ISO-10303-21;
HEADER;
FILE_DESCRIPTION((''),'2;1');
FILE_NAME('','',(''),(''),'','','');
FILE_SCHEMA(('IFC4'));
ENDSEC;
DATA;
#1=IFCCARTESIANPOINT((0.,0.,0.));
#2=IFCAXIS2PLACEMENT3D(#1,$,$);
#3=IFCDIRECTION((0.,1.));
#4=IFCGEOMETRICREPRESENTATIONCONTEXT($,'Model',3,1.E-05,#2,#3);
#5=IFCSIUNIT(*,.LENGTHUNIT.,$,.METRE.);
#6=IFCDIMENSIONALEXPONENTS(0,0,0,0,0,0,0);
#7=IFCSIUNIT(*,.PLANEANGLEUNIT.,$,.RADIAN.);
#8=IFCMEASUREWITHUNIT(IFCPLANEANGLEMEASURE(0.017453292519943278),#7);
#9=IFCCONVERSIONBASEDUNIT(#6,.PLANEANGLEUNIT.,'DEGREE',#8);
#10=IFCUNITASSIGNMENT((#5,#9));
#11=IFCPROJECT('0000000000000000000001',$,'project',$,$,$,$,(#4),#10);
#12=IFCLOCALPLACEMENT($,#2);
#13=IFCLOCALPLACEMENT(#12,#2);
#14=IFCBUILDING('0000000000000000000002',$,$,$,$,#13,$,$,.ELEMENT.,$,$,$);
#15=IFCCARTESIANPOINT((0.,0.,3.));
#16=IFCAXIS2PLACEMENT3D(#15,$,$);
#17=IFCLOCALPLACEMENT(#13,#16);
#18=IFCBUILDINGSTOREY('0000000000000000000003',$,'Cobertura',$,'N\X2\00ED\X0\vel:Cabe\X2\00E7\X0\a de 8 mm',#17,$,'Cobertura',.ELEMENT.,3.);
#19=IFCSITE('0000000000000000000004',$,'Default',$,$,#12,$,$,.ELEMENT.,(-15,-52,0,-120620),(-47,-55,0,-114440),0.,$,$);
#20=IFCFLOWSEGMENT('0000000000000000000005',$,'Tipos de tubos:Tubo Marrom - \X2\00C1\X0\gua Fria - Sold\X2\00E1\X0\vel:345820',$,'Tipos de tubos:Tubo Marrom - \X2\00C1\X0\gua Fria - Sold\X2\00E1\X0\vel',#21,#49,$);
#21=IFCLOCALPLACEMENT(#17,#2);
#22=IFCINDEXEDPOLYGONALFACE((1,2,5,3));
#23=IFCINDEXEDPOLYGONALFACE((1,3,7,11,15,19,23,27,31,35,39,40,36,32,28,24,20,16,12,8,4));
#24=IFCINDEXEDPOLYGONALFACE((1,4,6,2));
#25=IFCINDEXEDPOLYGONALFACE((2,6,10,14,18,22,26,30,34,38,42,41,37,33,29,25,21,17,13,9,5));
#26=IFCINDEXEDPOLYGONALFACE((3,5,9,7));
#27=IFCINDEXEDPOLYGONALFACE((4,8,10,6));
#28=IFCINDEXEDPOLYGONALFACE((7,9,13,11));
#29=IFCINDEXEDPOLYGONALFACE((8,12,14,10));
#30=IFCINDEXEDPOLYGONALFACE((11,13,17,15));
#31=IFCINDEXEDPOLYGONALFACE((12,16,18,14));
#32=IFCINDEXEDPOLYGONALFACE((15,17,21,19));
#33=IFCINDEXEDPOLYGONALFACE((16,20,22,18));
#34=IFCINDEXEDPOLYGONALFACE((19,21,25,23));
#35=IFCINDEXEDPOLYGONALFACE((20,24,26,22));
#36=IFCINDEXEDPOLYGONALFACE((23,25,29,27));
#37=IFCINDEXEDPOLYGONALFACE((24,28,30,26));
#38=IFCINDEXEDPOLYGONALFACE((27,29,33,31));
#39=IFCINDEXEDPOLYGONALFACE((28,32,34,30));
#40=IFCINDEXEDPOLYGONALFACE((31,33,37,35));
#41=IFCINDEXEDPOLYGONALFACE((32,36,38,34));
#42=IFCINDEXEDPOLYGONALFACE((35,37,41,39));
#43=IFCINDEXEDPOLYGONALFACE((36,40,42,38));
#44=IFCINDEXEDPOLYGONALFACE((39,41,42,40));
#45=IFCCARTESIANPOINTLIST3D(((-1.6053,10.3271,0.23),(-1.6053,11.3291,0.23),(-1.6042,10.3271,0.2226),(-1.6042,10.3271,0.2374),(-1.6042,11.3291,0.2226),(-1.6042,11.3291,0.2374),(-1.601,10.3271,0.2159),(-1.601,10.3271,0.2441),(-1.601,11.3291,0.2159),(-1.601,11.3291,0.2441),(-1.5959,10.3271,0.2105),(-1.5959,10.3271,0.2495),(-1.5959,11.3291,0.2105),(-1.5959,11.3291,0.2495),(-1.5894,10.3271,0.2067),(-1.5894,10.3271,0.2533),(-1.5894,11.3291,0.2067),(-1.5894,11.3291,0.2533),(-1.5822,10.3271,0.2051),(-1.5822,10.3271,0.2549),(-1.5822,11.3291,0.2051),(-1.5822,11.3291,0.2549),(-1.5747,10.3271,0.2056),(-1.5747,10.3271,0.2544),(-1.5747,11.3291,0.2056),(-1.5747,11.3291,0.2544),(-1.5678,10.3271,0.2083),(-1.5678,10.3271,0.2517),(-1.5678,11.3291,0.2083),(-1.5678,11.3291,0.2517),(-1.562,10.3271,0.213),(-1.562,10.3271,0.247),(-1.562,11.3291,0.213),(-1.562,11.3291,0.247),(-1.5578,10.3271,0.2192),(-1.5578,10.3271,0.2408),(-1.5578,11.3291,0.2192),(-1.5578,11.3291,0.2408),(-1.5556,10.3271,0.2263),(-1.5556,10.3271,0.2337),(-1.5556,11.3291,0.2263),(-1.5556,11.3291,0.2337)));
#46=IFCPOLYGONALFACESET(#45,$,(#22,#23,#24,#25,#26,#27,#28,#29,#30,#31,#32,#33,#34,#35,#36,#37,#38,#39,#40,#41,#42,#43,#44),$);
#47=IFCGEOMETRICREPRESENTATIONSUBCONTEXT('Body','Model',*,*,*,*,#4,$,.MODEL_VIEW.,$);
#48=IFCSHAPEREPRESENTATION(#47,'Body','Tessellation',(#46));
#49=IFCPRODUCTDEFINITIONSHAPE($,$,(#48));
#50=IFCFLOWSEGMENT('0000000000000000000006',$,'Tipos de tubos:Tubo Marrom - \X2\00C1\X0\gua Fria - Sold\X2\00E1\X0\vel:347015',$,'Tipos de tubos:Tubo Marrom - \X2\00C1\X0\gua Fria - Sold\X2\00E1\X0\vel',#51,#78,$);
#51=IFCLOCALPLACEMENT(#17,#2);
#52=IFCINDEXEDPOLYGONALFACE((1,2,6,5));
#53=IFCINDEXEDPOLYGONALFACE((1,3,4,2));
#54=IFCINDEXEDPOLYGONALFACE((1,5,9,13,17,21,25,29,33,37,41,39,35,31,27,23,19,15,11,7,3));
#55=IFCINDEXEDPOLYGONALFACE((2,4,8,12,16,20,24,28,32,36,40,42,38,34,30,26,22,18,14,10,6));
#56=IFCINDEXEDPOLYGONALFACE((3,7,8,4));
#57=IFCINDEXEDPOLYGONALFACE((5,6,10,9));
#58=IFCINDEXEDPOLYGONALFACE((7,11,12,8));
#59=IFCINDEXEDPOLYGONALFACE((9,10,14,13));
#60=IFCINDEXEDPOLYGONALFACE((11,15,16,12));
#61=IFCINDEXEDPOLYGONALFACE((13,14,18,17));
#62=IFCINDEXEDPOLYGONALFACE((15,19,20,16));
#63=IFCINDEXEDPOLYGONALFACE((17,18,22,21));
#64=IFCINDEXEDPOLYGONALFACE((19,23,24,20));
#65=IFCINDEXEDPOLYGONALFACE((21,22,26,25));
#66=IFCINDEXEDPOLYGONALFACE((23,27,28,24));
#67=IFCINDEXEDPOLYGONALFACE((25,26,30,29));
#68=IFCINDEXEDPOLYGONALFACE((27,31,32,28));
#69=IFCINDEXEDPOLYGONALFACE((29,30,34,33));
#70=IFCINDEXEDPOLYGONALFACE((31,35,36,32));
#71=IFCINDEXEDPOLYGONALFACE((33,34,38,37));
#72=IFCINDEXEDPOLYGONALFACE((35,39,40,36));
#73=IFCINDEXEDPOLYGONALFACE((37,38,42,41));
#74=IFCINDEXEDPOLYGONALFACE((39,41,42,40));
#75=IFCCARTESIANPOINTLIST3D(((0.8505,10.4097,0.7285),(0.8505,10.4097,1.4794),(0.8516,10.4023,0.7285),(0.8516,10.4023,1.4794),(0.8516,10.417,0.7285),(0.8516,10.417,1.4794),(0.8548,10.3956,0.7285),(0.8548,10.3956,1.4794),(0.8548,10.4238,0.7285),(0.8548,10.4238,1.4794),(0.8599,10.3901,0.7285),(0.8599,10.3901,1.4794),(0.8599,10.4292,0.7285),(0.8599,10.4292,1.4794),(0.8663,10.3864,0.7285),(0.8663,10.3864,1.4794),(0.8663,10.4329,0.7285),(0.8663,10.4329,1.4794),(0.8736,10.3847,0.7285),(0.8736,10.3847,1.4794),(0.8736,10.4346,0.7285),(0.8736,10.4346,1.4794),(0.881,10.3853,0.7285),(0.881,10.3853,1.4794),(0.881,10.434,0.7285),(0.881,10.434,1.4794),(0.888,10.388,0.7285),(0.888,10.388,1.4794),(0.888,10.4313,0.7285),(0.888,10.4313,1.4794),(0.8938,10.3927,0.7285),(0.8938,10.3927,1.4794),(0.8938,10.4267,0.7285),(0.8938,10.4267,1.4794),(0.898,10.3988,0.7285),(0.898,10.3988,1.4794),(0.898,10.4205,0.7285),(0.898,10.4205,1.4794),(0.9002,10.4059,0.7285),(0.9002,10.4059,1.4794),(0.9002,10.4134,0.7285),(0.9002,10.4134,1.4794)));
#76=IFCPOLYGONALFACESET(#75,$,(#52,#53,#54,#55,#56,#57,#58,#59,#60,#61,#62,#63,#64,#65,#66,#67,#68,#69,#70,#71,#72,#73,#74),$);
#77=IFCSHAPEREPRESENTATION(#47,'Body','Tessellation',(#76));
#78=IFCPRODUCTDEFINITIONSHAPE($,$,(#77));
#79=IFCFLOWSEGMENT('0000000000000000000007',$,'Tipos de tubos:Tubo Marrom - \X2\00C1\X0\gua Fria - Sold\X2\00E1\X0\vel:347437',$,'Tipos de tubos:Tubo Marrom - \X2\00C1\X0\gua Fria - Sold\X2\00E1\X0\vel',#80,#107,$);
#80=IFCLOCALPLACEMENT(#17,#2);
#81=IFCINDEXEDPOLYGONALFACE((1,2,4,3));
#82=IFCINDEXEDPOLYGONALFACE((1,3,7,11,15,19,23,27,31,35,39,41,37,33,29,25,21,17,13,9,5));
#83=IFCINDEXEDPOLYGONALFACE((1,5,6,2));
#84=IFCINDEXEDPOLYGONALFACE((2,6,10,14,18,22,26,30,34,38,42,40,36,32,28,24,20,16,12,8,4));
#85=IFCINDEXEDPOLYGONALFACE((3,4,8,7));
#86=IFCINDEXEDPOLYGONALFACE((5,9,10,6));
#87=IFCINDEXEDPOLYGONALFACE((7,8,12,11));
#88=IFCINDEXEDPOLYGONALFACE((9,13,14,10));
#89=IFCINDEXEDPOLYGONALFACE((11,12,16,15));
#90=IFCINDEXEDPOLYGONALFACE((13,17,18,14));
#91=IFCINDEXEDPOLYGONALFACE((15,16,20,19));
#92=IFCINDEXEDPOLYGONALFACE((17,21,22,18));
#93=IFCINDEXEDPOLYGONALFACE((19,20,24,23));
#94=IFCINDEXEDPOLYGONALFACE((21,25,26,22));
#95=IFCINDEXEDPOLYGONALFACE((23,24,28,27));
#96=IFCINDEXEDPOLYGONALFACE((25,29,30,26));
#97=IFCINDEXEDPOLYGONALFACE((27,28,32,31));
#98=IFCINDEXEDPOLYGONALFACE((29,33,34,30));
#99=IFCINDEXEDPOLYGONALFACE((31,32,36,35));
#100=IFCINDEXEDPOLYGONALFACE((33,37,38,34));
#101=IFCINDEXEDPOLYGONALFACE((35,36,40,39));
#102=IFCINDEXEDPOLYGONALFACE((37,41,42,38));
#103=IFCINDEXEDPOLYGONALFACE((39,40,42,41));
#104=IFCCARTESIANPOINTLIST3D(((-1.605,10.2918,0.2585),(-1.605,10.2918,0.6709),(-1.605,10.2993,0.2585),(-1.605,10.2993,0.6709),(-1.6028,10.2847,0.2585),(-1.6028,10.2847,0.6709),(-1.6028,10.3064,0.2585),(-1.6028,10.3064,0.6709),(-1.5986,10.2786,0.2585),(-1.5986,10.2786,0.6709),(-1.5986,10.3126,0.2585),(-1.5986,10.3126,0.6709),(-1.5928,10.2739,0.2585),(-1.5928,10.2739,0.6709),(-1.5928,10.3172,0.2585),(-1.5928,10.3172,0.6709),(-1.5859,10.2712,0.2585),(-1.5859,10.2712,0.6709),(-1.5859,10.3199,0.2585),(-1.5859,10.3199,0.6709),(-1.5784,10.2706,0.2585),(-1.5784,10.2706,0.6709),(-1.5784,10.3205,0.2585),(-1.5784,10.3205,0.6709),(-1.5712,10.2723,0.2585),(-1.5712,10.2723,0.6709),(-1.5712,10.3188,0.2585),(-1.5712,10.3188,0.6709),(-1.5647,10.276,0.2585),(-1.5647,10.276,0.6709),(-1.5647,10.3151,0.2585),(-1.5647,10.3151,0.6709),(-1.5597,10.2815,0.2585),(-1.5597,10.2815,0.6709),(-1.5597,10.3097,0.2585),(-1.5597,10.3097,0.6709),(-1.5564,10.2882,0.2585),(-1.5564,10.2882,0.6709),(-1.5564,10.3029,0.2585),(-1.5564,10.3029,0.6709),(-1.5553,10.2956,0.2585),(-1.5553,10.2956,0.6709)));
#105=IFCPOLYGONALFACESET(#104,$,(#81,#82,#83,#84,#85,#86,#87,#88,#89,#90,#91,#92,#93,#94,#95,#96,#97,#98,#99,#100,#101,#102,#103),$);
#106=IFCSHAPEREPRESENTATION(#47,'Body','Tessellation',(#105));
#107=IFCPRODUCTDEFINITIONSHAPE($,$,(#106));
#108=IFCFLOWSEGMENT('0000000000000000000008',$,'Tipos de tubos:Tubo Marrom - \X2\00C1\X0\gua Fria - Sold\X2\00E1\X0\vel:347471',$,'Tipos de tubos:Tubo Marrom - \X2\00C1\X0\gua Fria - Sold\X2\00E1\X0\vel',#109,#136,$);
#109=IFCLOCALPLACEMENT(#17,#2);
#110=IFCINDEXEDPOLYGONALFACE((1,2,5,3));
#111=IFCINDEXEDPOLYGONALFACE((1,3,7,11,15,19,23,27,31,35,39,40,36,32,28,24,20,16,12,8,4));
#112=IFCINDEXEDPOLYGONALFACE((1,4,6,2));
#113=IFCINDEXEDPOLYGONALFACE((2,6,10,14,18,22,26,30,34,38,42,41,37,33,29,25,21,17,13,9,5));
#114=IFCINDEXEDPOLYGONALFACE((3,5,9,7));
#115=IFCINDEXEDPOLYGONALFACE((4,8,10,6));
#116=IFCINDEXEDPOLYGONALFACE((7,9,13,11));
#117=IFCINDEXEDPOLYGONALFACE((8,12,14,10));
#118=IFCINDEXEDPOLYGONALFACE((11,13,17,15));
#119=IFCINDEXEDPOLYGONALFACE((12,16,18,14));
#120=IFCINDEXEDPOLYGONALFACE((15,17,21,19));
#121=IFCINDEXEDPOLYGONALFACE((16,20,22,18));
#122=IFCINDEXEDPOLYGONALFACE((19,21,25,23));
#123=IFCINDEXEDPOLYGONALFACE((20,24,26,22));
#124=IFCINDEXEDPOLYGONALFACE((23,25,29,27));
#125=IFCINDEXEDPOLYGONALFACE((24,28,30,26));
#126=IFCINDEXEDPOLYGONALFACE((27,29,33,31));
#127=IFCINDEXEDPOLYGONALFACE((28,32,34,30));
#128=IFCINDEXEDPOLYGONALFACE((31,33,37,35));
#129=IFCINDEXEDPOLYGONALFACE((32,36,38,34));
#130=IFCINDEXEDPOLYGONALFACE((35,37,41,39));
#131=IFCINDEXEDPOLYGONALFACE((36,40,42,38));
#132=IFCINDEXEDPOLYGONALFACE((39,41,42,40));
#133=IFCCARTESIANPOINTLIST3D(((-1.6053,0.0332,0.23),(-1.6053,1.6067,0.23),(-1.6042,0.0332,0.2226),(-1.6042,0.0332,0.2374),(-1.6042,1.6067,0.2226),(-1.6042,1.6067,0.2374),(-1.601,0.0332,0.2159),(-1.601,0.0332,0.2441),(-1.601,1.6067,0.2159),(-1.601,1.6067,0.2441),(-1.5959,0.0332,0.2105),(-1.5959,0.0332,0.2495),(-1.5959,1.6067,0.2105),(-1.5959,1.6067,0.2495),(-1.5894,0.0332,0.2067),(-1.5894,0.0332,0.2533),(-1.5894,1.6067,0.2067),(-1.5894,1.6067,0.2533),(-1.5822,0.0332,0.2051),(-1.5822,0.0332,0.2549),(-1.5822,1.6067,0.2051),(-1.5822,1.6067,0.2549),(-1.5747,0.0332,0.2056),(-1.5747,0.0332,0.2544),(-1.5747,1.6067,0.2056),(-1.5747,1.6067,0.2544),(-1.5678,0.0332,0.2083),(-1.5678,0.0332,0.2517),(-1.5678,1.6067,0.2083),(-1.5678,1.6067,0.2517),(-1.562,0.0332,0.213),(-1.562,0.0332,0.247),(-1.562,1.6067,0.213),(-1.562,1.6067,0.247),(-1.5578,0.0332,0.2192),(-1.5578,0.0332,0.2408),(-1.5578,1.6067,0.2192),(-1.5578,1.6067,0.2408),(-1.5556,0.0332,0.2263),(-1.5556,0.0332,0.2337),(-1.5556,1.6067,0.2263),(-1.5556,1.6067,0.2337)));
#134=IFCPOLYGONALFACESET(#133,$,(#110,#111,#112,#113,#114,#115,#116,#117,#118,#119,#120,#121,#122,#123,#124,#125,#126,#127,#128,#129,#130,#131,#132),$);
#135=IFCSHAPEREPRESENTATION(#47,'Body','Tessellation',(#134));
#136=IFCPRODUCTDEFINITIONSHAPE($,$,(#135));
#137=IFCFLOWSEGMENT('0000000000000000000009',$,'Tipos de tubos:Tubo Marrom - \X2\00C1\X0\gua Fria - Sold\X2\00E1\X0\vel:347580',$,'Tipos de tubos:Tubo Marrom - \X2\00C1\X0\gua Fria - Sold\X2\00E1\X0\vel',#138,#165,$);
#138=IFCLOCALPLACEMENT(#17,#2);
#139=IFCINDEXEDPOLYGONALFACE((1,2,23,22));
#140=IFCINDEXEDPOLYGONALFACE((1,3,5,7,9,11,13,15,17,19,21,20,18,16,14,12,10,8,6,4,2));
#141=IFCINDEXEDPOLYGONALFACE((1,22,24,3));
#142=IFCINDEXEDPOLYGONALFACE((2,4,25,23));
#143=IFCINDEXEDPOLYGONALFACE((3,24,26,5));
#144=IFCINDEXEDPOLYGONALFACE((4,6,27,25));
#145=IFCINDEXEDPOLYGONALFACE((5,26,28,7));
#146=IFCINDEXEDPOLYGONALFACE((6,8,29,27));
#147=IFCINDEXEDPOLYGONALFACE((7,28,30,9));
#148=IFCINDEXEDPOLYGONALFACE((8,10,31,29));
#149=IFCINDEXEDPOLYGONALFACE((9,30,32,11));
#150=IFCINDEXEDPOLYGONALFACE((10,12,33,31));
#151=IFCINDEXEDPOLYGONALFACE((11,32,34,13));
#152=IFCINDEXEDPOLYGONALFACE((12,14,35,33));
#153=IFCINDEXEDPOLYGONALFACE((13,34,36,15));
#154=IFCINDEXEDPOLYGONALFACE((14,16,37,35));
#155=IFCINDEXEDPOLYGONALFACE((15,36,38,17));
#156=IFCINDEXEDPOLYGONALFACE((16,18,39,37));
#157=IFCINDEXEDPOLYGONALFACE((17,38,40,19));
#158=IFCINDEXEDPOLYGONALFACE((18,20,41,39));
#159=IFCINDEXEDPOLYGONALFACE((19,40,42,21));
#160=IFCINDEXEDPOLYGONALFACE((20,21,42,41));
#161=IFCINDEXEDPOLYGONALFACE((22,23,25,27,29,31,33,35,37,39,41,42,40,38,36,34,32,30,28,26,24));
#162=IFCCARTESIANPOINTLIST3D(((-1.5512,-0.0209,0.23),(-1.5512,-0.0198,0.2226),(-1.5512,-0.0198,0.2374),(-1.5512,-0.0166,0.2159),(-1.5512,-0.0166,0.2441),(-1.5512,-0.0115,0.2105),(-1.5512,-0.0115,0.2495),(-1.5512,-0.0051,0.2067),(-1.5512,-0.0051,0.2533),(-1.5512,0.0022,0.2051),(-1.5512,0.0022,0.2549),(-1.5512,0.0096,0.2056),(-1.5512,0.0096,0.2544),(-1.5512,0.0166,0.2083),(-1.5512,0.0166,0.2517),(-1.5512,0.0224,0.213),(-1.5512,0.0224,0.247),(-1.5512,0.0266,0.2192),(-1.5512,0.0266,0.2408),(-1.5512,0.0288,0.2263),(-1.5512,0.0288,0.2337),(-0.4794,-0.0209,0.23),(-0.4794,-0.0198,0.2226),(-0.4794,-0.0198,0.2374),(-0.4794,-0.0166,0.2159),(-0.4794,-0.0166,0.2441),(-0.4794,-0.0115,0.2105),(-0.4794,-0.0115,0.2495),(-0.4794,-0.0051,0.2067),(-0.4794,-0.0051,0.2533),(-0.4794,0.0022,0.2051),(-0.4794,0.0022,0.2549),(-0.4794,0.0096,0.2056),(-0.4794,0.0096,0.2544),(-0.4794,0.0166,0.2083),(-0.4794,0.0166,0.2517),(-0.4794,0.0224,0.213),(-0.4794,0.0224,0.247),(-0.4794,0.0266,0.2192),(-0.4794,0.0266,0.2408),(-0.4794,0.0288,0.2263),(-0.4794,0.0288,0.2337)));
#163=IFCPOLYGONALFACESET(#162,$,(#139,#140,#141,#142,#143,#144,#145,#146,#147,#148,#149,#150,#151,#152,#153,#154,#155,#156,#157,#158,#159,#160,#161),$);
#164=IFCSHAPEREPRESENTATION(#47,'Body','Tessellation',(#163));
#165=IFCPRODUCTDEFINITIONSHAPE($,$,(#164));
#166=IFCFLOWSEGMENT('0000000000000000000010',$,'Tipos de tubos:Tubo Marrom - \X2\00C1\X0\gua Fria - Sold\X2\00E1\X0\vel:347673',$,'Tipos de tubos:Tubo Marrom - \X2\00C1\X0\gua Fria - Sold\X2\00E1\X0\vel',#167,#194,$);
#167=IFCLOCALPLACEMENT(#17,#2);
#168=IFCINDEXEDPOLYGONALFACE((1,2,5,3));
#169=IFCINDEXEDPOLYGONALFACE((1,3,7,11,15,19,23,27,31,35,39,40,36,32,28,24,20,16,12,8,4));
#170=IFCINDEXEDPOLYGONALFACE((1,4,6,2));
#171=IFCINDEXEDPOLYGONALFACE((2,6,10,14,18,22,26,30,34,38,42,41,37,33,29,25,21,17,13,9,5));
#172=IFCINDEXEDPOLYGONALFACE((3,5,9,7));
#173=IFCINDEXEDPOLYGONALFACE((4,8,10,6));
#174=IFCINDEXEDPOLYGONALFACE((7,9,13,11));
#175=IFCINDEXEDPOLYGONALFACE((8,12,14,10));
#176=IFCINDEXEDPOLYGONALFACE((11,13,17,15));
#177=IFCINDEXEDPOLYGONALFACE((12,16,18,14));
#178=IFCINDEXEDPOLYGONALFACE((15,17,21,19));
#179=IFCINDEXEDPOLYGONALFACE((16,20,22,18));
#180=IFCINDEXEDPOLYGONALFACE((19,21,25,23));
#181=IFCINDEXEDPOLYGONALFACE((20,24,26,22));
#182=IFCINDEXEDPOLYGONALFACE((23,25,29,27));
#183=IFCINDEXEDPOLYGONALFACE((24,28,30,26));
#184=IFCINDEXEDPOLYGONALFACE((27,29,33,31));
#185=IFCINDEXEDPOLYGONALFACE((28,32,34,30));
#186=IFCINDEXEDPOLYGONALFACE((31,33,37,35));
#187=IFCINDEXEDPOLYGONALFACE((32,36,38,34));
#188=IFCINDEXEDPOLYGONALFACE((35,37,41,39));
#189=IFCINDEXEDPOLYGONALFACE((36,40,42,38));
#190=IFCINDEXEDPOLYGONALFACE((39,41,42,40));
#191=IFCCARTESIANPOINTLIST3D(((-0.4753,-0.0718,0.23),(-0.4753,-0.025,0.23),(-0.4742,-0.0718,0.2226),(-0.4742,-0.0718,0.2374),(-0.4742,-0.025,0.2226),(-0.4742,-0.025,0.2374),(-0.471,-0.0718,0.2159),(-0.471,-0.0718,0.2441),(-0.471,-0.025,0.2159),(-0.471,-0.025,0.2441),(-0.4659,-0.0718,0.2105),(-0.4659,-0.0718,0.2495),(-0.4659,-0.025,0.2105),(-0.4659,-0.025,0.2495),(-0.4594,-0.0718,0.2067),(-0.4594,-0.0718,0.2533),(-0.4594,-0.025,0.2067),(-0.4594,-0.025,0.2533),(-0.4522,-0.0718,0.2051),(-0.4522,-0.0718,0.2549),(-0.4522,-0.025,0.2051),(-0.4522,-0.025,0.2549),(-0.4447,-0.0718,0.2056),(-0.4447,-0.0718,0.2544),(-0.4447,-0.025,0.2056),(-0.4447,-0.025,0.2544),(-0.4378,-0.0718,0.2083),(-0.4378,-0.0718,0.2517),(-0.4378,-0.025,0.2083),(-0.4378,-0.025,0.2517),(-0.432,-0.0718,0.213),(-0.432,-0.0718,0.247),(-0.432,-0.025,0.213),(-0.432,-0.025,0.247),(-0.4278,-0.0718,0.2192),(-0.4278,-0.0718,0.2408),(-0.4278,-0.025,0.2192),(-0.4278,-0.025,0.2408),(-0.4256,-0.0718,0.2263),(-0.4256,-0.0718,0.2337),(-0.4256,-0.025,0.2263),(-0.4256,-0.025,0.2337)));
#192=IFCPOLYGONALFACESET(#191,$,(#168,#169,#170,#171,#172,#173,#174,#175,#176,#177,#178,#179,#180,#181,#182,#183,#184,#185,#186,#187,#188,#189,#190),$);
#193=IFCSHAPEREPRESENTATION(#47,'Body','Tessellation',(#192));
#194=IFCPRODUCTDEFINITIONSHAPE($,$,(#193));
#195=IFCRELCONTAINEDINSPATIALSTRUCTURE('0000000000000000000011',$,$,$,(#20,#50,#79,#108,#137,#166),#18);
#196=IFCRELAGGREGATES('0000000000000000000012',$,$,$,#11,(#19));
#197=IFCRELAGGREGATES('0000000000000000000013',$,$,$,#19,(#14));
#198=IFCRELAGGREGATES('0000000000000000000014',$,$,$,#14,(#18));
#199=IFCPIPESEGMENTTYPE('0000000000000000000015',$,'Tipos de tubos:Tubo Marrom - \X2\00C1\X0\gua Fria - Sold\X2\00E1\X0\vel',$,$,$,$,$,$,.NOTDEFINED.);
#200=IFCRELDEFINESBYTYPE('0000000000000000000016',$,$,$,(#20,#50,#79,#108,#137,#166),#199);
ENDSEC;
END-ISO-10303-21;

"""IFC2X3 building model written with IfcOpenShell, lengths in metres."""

from ifc_helpers import new_model, entity, si_unit, converted_unit, direction, frame, frame_2d, origin, place, context, subcontext, project, spatial, circle, extrude, type_object, element, save


model = new_model("IFC2X3")

# Units and contexts
model_context = context("Model", 3, precision=1e-05, world=origin(), true_north=direction((0.0, 1.0)))
body_context = subcontext(model_context, "Body", "Model", "MODEL_VIEW")
ifc_project = project(units=[si_unit("LENGTHUNIT", "METRE"), converted_unit("PLANEANGLEUNIT", "DEGREE", entity("IfcPlaneAngleMeasure", 0.017453292519943278), si_unit("PLANEANGLEUNIT", "RADIAN"), dimensions=[0, 0, 0, 0, 0, 0, 0])], contexts=[model_context])

# Site, building, storey
site_placement = place(None, origin())
site = spatial("IfcSite", under=ifc_project, at=site_placement, Name="Default", CompositionType="ELEMENT", RefLatitude=(-15, -52, 0, -120620), RefLongitude=(-47, -55, 0, -114440), RefElevation=0.0)
building_placement = place(site_placement, origin())
building = spatial("IfcBuilding", under=site, at=building_placement, CompositionType="ELEMENT")
storey_placement = place(building_placement, frame((0.0, 0.0, 3.0)))
storey = spatial("IfcBuildingStorey", under=building, at=storey_placement, Name="Cobertura", ObjectType="Nível:Cabeça de 8 mm", LongName="Cobertura", CompositionType="ELEMENT", Elevation=3.0)

# Flow segments
pipe_segment_type = type_object("IfcPipeSegmentType", Name="Tipos de tubos:Tubo Marrom - Água Fria - Soldável", PredefinedType="NOTDEFINED")
flow_segment_1_placement = place(storey_placement, origin())
element("IfcFlowSegment", 1, at=flow_segment_1_placement, inside=storey, type_object=pipe_segment_type, Name="Tipos de tubos:Tubo Marrom - Água Fria - Soldável:345820", ObjectType="Tipos de tubos:Tubo Marrom - Água Fria - Soldável", context=body_context, shape_type="SweptSolid", body=[
    extrude(circle(Radius=0.025, at=frame_2d((0.0, 0.0), x_axis=(1.0, 0.0))), frame((-1.5803, 10.3271, 0.23), z_axis=(0.0, 1.0, 0.0), x_axis=(-1.0, 0.0, 0.0)), (0.0, 0.0, 1.0), 1.002),
])
flow_segment_2_placement = place(storey_placement, origin())
element("IfcFlowSegment", 2, at=flow_segment_2_placement, inside=storey, type_object=pipe_segment_type, Name="Tipos de tubos:Tubo Marrom - Água Fria - Soldável:347015", ObjectType="Tipos de tubos:Tubo Marrom - Água Fria - Soldável", context=body_context, shape_type="SweptSolid", body=[
    extrude(circle(Radius=0.025, at=frame_2d((0.0, 0.0), x_axis=(1.0, 0.0))), frame((0.8755, 10.4097, 0.7285), z_axis=(0.0, 0.0, 1.0), x_axis=(-1.0, 0.0, 0.0)), (0.0, 0.0, 1.0), 0.7509),
])
flow_segment_3_placement = place(storey_placement, origin())
element("IfcFlowSegment", 3, at=flow_segment_3_placement, inside=storey, type_object=pipe_segment_type, Name="Tipos de tubos:Tubo Marrom - Água Fria - Soldável:347437", ObjectType="Tipos de tubos:Tubo Marrom - Água Fria - Soldável", context=body_context, shape_type="SweptSolid", body=[
    extrude(circle(Radius=0.025, at=frame_2d((0.0, 0.0), x_axis=(1.0, 0.0))), frame((-1.5803, 10.2956, 0.2585)), (0.0, 0.0, 1.0), 0.4124),
])
flow_segment_4_placement = place(storey_placement, origin())
element("IfcFlowSegment", 4, at=flow_segment_4_placement, inside=storey, type_object=pipe_segment_type, Name="Tipos de tubos:Tubo Marrom - Água Fria - Soldável:347471", ObjectType="Tipos de tubos:Tubo Marrom - Água Fria - Soldável", context=body_context, shape_type="SweptSolid", body=[
    extrude(circle(Radius=0.025, at=frame_2d((0.0, 0.0), x_axis=(1.0, 0.0))), frame((-1.5803, 0.0332, 0.23), z_axis=(0.0, 1.0, 0.0), x_axis=(-1.0, 0.0, 0.0)), (0.0, 0.0, 1.0), 1.5735),
])
flow_segment_5_placement = place(storey_placement, origin())
element("IfcFlowSegment", 5, at=flow_segment_5_placement, inside=storey, type_object=pipe_segment_type, Name="Tipos de tubos:Tubo Marrom - Água Fria - Soldável:347580", ObjectType="Tipos de tubos:Tubo Marrom - Água Fria - Soldável", context=body_context, shape_type="SweptSolid", body=[
    extrude(circle(Radius=0.025, at=frame_2d((0.0, 0.0), x_axis=(1.0, 0.0))), frame((-1.5512, 0.0041, 0.23), z_axis=(1.0, 0.0, 0.0), x_axis=(0.0, -1.0, 0.0)), (0.0, 0.0, 1.0), 1.0718),
])
flow_segment_6_placement = place(storey_placement, origin())
element("IfcFlowSegment", 6, at=flow_segment_6_placement, inside=storey, type_object=pipe_segment_type, Name="Tipos de tubos:Tubo Marrom - Água Fria - Soldável:347673", ObjectType="Tipos de tubos:Tubo Marrom - Água Fria - Soldável", context=body_context, shape_type="SweptSolid", body=[
    extrude(circle(Radius=0.025, at=frame_2d((0.0, 0.0), x_axis=(1.0, 0.0))), frame((-0.4503, -0.0718, 0.23), z_axis=(0.0, 1.0, 0.0), x_axis=(-1.0, 0.0, 0.0)), (0.0, 0.0, 1.0), 0.0468),
])

save(model, "model.ifc")
